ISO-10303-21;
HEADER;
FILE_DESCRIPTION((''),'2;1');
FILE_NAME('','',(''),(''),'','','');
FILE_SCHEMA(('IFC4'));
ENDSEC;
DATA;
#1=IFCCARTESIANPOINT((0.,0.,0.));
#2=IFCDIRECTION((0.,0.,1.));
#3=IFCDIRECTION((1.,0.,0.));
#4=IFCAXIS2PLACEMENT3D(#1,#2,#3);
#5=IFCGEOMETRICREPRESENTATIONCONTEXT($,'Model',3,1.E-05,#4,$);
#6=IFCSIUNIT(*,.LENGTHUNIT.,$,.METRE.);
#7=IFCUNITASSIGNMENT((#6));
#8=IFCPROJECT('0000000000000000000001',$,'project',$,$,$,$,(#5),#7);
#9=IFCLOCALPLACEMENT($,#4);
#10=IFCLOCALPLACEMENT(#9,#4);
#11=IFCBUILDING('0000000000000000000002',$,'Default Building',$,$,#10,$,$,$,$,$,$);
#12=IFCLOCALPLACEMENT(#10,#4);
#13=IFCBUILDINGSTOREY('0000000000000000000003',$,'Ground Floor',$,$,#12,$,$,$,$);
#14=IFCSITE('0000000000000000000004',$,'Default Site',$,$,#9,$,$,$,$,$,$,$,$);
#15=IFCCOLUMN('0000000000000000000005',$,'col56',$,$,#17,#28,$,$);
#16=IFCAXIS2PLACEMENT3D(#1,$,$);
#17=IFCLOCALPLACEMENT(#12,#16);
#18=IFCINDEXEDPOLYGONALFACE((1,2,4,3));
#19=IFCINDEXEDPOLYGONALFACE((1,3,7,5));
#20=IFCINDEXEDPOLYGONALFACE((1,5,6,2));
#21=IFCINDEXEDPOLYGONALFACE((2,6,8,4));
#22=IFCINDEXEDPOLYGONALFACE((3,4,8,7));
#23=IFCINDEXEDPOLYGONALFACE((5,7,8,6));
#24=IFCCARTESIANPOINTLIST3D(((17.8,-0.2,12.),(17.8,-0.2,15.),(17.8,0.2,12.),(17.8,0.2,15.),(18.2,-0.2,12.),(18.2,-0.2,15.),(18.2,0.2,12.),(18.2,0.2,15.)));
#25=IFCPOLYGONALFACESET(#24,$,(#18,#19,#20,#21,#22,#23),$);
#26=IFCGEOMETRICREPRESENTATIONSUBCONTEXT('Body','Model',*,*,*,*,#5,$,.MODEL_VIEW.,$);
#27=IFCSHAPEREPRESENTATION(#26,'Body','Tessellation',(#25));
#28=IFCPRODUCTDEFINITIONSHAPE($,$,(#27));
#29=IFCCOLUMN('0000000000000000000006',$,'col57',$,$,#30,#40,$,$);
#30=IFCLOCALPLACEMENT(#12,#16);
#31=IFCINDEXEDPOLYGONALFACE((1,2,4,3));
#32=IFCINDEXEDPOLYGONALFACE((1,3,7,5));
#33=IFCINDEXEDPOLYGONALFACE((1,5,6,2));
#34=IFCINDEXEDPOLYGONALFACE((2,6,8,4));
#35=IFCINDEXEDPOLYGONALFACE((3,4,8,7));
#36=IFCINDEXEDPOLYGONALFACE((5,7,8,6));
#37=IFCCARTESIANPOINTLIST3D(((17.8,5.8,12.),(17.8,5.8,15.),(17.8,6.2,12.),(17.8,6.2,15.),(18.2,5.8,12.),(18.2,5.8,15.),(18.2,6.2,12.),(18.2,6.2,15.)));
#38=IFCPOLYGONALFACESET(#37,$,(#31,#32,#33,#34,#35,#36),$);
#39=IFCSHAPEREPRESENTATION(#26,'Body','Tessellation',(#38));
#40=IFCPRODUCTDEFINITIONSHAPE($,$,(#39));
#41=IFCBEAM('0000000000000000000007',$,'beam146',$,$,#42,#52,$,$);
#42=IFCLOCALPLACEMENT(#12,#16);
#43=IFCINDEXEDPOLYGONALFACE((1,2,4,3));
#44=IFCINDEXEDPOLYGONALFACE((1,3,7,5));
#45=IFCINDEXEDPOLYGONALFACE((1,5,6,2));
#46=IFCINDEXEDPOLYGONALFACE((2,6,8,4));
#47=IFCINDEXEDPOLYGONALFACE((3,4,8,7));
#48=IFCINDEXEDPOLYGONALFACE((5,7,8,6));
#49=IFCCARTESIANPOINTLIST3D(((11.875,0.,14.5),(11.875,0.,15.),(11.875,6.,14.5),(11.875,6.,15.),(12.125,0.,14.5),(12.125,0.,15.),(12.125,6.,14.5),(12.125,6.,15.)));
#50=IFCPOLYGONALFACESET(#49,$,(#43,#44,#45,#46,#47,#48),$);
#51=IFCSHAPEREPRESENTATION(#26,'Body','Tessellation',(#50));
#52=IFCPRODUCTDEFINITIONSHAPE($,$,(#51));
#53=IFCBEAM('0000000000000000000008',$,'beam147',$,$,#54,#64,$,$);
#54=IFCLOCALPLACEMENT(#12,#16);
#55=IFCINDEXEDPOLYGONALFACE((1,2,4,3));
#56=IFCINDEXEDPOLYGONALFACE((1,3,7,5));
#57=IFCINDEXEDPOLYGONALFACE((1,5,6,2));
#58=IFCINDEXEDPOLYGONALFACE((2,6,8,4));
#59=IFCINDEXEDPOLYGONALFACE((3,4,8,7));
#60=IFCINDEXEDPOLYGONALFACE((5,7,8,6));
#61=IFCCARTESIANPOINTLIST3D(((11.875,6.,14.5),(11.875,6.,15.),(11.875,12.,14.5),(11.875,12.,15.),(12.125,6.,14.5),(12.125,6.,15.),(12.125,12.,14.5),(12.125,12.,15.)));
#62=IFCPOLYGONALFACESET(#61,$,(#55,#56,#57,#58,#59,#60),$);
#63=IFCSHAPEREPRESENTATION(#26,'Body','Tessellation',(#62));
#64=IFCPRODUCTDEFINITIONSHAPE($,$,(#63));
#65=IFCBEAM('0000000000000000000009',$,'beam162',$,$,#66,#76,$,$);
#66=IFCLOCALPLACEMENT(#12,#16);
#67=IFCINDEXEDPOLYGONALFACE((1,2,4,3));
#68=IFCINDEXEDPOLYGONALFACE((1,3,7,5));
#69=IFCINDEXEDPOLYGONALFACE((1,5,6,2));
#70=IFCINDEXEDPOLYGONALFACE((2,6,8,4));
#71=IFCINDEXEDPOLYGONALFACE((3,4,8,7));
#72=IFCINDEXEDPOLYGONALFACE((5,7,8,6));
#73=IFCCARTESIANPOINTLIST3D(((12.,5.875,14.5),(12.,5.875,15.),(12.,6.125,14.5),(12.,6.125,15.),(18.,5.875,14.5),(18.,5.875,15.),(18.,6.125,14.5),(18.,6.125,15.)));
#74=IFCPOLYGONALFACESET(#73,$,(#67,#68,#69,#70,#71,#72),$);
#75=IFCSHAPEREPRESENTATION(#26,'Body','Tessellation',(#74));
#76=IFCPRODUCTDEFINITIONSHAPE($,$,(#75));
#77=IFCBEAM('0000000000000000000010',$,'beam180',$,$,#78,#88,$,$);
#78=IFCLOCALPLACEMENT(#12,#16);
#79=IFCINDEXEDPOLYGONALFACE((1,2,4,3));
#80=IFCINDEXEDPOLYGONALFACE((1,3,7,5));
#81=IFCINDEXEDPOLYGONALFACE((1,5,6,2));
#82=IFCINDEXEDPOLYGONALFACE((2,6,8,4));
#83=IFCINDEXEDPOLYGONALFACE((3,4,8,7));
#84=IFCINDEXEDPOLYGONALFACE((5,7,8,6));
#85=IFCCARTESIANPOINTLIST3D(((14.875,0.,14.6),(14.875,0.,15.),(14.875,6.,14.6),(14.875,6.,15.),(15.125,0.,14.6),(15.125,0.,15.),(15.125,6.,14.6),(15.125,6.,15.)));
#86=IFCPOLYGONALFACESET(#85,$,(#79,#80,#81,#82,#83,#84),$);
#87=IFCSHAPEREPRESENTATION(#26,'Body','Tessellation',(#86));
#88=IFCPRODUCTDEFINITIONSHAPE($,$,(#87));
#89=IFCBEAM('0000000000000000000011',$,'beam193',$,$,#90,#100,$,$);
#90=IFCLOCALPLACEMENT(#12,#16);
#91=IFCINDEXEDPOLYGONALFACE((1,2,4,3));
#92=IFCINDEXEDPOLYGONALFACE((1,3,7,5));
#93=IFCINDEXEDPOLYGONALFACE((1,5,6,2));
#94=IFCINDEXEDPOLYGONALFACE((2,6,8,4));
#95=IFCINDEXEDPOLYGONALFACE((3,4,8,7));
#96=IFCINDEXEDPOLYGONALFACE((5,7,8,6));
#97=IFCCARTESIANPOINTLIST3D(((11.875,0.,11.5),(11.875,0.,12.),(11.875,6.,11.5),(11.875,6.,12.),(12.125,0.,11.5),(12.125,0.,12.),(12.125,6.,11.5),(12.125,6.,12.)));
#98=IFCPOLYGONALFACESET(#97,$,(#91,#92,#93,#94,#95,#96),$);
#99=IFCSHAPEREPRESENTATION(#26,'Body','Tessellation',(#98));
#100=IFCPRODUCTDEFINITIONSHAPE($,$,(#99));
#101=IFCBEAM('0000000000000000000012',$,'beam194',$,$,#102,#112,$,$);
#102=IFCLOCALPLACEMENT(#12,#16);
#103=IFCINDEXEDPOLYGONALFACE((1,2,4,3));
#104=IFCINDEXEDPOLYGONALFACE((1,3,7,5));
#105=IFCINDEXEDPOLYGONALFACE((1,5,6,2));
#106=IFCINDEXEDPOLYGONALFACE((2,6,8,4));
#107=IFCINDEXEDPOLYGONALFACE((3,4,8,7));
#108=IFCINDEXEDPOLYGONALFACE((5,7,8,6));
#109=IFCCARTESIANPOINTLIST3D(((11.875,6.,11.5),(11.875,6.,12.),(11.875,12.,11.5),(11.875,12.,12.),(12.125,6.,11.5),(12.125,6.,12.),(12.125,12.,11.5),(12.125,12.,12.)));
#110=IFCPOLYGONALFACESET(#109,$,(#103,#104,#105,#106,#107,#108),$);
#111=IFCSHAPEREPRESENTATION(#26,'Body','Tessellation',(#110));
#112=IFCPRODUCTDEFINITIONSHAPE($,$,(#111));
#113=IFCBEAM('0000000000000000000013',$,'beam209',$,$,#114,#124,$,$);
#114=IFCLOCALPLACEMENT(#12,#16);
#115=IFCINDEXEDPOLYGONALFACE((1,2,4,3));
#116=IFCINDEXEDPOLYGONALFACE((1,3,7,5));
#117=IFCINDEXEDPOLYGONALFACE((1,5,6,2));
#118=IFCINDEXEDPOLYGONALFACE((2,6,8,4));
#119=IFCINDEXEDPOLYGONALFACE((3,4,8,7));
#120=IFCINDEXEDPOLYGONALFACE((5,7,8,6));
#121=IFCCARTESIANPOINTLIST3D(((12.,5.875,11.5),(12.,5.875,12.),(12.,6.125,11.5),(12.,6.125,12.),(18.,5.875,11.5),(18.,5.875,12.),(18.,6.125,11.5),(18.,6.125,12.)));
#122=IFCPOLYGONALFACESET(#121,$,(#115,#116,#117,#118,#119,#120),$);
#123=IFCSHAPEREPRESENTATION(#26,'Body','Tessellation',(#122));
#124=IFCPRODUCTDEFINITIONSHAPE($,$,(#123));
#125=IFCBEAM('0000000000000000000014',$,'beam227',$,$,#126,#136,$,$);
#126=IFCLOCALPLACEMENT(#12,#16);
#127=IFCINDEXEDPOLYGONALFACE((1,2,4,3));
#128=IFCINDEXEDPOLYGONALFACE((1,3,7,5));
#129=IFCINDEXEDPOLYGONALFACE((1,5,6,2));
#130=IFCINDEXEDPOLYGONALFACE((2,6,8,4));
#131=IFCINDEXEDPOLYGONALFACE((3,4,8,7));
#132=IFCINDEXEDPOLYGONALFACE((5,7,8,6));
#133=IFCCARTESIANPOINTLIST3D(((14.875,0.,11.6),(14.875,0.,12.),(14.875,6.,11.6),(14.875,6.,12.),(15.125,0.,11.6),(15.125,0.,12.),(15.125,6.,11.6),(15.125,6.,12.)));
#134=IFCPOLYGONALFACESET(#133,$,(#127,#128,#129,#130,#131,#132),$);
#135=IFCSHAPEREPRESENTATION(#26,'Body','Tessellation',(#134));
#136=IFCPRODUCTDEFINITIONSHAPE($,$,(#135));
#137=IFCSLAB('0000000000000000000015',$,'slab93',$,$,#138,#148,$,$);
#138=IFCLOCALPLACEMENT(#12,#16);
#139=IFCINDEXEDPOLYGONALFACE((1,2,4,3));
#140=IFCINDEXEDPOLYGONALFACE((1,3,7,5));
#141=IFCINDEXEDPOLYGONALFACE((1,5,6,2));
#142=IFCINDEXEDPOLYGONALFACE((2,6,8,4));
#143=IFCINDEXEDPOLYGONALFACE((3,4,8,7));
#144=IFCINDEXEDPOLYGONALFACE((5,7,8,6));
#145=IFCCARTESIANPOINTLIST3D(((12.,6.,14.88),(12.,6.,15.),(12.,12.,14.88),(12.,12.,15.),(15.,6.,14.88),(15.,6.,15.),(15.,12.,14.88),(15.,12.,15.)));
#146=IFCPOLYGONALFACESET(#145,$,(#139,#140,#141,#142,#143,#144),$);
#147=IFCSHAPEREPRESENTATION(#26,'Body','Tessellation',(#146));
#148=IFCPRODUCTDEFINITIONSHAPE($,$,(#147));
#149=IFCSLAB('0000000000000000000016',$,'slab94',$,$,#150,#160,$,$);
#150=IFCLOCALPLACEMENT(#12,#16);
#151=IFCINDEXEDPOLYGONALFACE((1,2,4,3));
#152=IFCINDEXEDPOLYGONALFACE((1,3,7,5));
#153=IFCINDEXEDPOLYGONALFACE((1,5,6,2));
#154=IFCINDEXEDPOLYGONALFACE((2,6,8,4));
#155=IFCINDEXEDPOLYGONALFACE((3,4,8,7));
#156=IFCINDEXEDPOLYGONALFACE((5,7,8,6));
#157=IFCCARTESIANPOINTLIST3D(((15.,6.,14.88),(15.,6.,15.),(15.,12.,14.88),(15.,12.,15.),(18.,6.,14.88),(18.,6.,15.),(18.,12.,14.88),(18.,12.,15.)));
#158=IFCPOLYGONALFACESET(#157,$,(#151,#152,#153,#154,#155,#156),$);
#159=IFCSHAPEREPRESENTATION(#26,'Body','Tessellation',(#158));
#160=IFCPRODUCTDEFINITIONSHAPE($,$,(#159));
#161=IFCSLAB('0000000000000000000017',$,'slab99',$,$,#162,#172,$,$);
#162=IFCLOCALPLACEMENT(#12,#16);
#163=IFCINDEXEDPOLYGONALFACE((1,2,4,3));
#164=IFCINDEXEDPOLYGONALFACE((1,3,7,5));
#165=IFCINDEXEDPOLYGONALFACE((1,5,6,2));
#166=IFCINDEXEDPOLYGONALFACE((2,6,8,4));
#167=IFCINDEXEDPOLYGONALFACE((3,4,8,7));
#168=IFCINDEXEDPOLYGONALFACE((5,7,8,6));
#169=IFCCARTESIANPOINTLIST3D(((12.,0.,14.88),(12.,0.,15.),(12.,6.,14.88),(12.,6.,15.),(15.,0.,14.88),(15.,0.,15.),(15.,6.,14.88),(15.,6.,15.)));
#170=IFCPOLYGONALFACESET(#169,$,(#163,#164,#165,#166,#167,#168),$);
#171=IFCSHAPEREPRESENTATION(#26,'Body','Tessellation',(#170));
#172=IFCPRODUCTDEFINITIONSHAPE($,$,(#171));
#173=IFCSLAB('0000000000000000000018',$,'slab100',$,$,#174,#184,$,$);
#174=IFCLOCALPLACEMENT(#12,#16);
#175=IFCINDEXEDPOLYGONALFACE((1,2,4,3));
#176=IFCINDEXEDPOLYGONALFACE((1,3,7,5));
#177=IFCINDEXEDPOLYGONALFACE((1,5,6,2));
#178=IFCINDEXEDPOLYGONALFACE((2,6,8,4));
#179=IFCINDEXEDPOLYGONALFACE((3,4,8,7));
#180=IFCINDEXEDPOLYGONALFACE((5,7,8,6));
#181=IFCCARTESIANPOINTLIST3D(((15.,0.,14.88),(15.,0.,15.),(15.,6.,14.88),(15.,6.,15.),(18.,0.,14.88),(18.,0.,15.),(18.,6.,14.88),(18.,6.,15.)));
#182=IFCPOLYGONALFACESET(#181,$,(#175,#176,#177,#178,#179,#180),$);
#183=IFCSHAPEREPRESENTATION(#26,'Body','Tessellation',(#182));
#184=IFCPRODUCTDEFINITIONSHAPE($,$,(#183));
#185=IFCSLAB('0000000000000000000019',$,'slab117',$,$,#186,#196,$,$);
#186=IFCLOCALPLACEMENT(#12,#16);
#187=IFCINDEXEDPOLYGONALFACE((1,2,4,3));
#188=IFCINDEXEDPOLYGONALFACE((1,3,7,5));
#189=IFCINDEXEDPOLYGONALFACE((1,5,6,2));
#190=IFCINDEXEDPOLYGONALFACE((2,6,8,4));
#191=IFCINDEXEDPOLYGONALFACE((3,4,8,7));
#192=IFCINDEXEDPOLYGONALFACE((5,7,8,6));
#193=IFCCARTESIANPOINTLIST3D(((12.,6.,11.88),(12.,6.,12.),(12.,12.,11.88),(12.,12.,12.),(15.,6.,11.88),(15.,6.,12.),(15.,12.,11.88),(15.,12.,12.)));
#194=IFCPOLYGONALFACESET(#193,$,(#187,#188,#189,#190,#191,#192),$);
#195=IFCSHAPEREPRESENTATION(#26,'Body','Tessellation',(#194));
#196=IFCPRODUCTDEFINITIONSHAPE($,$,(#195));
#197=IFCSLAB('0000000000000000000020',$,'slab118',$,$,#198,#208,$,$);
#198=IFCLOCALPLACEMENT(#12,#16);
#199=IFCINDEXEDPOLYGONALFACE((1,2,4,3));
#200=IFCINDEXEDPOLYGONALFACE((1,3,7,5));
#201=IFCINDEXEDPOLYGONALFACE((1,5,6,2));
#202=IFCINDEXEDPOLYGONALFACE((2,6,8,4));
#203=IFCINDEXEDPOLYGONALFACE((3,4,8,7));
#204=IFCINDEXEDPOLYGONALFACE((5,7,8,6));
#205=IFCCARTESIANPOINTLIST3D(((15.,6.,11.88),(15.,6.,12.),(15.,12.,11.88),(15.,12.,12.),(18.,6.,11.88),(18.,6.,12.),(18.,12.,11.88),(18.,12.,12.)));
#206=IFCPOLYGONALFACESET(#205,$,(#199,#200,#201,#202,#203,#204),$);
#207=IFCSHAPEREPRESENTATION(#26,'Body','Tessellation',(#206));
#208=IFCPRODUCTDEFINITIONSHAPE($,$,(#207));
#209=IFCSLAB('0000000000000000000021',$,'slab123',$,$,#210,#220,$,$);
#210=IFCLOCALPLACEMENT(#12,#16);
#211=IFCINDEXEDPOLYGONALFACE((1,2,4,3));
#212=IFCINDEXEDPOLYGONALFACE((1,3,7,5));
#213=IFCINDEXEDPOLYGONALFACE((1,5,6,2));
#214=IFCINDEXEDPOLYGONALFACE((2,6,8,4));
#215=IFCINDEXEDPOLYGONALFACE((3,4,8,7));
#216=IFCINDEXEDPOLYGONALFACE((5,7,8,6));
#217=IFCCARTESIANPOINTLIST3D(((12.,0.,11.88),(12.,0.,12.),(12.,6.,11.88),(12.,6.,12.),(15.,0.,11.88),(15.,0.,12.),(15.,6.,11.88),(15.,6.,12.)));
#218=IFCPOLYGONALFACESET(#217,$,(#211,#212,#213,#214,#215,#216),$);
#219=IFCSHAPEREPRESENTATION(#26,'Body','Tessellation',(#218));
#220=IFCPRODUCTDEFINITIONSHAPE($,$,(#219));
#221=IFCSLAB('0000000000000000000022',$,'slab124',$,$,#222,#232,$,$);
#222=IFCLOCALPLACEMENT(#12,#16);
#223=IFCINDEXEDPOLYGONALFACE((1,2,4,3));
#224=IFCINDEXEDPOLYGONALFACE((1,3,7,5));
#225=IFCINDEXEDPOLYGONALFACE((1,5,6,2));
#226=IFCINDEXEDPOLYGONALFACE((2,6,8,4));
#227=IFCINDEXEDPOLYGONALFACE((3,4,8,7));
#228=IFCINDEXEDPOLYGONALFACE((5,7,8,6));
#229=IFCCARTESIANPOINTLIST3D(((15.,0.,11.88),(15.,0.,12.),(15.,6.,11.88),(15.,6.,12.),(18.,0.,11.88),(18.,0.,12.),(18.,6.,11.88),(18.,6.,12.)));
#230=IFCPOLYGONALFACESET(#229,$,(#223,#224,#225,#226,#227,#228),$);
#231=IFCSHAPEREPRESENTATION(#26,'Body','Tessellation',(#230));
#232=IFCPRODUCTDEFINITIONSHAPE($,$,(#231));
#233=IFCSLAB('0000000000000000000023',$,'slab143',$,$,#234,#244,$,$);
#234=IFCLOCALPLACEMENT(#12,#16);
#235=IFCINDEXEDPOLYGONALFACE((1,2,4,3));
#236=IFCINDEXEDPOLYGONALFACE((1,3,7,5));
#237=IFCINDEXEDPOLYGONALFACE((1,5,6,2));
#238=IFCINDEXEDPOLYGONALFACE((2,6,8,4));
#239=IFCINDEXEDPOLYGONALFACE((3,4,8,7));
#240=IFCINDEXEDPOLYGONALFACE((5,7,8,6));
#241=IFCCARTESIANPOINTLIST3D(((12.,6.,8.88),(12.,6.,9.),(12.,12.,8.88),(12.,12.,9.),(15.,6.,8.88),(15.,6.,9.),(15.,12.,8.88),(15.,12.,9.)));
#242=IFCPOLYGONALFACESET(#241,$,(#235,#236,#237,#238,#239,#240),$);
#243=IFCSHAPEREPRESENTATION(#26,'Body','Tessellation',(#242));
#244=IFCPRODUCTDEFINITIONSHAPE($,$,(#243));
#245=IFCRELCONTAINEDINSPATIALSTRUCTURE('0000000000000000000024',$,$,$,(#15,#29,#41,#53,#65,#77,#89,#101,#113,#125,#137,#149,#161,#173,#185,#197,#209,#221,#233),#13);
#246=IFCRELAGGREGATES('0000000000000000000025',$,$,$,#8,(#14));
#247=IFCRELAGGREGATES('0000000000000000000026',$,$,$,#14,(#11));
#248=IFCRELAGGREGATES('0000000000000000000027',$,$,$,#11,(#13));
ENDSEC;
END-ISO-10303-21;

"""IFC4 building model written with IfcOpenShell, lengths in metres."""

from ifc_helpers import new_model, si_unit, frame, origin_with_axes, place, context, subcontext, project, spatial, indexed_curve, outline, extrude, element, save


model = new_model("IFC4")

# Units and contexts
model_context = context("Model", 3, precision=1e-05, world=origin_with_axes())
body_context = subcontext(model_context, "Body", "Model", "MODEL_VIEW")
ifc_project = project(units=[si_unit("LENGTHUNIT", "METRE")], contexts=[model_context])

# Site, building, storey
site_placement = place(None, origin_with_axes())
site = spatial("IfcSite", under=ifc_project, at=site_placement, Name="Default Site")
building_placement = place(site_placement, origin_with_axes())
building = spatial("IfcBuilding", under=site, at=building_placement, Name="Default Building")
storey_placement = place(building_placement, origin_with_axes())
storey = spatial("IfcBuildingStorey", under=building, at=storey_placement, Name="Ground Floor")

# Columns
for number, where, z_axis, x_axis, name in (
    (1, (17.8, -0.2, 12.0), (0.0, 0.0, 1.0), (1.0, 0.0, 0.0), "col56"),
    (2, (17.8, 5.8, 12.0), (0.0, 0.0, 1.0), (1.0, 0.0, 0.0), "col57"),
):
    element("IfcColumn", number, at=place(storey_placement, frame(where, z_axis=z_axis, x_axis=x_axis)), inside=storey, Name=name, context=body_context, shape_type="SweptSolid", body=[
        extrude(outline(indexed_curve([(0.0, 0.0), (0.0, 0.4), (0.4, 0.4), (0.4, 0.0), (0.0, 0.0)], self_intersect=False)), origin_with_axes(), (0.0, 0.0, 1.0), 3.0),
    ])

# Beams
for number, where, z_axis, x_axis, name in (
    (3, (12.125, 0.0, 14.5), (0.0, 0.0, 1.0), (0.0, 1.0, 0.0), "beam146"),
    (4, (12.125, 6.0, 14.5), (0.0, 0.0, 1.0), (0.0, 1.0, 0.0), "beam147"),
    (5, (12.0, 5.875, 14.5), (0.0, 0.0, 1.0), (1.0, 0.0, 0.0), "beam162"),
):
    element("IfcBeam", number, at=place(storey_placement, frame(where, z_axis=z_axis, x_axis=x_axis)), inside=storey, Name=name, context=body_context, shape_type="SweptSolid", body=[
        extrude(outline(indexed_curve([(0.0, 0.0), (0.0, 0.25), (6.0, 0.25), (6.0, 0.0), (0.0, 0.0)], self_intersect=False)), origin_with_axes(), (0.0, 0.0, 1.0), 0.5),
    ])
beam_1_placement = place(storey_placement, frame((14.875, 6.0, 14.6), z_axis=(0.0, 0.0, 1.0), x_axis=(0.0, -1.0, 0.0)))
element("IfcBeam", 6, at=beam_1_placement, inside=storey, Name="beam180", context=body_context, shape_type="SweptSolid", body=[
    extrude(outline(indexed_curve([(0.0, 0.0), (0.0, 0.25), (6.0, 0.25), (6.0, 0.0), (0.0, 0.0)], self_intersect=False)), origin_with_axes(), (0.0, 0.0, 1.0), 0.4),
])
for number, where, z_axis, x_axis, name in (
    (7, (12.125, 0.0, 11.5), (0.0, 0.0, 1.0), (0.0, 1.0, 0.0), "beam193"),
    (8, (12.125, 6.0, 11.5), (0.0, 0.0, 1.0), (0.0, 1.0, 0.0), "beam194"),
    (9, (12.0, 5.875, 11.5), (0.0, 0.0, 1.0), (1.0, 0.0, 0.0), "beam209"),
):
    element("IfcBeam", number, at=place(storey_placement, frame(where, z_axis=z_axis, x_axis=x_axis)), inside=storey, Name=name, context=body_context, shape_type="SweptSolid", body=[
        extrude(outline(indexed_curve([(0.0, 0.0), (0.0, 0.25), (6.0, 0.25), (6.0, 0.0), (0.0, 0.0)], self_intersect=False)), origin_with_axes(), (0.0, 0.0, 1.0), 0.5),
    ])
beam_2_placement = place(storey_placement, frame((14.875, 6.0, 11.6), z_axis=(0.0, 0.0, 1.0), x_axis=(0.0, -1.0, 0.0)))
element("IfcBeam", 10, at=beam_2_placement, inside=storey, Name="beam227", context=body_context, shape_type="SweptSolid", body=[
    extrude(outline(indexed_curve([(0.0, 0.0), (0.0, 0.25), (6.0, 0.25), (6.0, 0.0), (0.0, 0.0)], self_intersect=False)), origin_with_axes(), (0.0, 0.0, 1.0), 0.4),
])

# Slabs
for number, where, z_axis, x_axis, name in (
    (11, (12.0, 6.0, 14.88), (0.0, 0.0, 1.0), (1.0, 0.0, 0.0), "slab93"),
    (12, (15.0, 6.0, 14.88), (0.0, 0.0, 1.0), (1.0, 0.0, 0.0), "slab94"),
    (13, (12.0, 0.0, 14.88), (0.0, 0.0, 1.0), (1.0, 0.0, 0.0), "slab99"),
    (14, (15.0, 0.0, 14.88), (0.0, 0.0, 1.0), (1.0, 0.0, 0.0), "slab100"),
    (15, (12.0, 6.0, 11.88), (0.0, 0.0, 1.0), (1.0, 0.0, 0.0), "slab117"),
    (16, (15.0, 6.0, 11.88), (0.0, 0.0, 1.0), (1.0, 0.0, 0.0), "slab118"),
    (17, (12.0, 0.0, 11.88), (0.0, 0.0, 1.0), (1.0, 0.0, 0.0), "slab123"),
    (18, (15.0, 0.0, 11.88), (0.0, 0.0, 1.0), (1.0, 0.0, 0.0), "slab124"),
    (19, (12.0, 6.0, 8.88), (0.0, 0.0, 1.0), (1.0, 0.0, 0.0), "slab143"),
):
    element("IfcSlab", number, at=place(storey_placement, frame(where, z_axis=z_axis, x_axis=x_axis)), inside=storey, Name=name, context=body_context, shape_type="SweptSolid", body=[
        extrude(outline(indexed_curve([(0.0, 0.0), (0.0, 6.0), (3.0, 6.0), (3.0, 0.0), (0.0, 0.0)], self_intersect=False)), origin_with_axes(), (0.0, 0.0, 1.0), 0.12),
    ])

save(model, "model.ifc")
